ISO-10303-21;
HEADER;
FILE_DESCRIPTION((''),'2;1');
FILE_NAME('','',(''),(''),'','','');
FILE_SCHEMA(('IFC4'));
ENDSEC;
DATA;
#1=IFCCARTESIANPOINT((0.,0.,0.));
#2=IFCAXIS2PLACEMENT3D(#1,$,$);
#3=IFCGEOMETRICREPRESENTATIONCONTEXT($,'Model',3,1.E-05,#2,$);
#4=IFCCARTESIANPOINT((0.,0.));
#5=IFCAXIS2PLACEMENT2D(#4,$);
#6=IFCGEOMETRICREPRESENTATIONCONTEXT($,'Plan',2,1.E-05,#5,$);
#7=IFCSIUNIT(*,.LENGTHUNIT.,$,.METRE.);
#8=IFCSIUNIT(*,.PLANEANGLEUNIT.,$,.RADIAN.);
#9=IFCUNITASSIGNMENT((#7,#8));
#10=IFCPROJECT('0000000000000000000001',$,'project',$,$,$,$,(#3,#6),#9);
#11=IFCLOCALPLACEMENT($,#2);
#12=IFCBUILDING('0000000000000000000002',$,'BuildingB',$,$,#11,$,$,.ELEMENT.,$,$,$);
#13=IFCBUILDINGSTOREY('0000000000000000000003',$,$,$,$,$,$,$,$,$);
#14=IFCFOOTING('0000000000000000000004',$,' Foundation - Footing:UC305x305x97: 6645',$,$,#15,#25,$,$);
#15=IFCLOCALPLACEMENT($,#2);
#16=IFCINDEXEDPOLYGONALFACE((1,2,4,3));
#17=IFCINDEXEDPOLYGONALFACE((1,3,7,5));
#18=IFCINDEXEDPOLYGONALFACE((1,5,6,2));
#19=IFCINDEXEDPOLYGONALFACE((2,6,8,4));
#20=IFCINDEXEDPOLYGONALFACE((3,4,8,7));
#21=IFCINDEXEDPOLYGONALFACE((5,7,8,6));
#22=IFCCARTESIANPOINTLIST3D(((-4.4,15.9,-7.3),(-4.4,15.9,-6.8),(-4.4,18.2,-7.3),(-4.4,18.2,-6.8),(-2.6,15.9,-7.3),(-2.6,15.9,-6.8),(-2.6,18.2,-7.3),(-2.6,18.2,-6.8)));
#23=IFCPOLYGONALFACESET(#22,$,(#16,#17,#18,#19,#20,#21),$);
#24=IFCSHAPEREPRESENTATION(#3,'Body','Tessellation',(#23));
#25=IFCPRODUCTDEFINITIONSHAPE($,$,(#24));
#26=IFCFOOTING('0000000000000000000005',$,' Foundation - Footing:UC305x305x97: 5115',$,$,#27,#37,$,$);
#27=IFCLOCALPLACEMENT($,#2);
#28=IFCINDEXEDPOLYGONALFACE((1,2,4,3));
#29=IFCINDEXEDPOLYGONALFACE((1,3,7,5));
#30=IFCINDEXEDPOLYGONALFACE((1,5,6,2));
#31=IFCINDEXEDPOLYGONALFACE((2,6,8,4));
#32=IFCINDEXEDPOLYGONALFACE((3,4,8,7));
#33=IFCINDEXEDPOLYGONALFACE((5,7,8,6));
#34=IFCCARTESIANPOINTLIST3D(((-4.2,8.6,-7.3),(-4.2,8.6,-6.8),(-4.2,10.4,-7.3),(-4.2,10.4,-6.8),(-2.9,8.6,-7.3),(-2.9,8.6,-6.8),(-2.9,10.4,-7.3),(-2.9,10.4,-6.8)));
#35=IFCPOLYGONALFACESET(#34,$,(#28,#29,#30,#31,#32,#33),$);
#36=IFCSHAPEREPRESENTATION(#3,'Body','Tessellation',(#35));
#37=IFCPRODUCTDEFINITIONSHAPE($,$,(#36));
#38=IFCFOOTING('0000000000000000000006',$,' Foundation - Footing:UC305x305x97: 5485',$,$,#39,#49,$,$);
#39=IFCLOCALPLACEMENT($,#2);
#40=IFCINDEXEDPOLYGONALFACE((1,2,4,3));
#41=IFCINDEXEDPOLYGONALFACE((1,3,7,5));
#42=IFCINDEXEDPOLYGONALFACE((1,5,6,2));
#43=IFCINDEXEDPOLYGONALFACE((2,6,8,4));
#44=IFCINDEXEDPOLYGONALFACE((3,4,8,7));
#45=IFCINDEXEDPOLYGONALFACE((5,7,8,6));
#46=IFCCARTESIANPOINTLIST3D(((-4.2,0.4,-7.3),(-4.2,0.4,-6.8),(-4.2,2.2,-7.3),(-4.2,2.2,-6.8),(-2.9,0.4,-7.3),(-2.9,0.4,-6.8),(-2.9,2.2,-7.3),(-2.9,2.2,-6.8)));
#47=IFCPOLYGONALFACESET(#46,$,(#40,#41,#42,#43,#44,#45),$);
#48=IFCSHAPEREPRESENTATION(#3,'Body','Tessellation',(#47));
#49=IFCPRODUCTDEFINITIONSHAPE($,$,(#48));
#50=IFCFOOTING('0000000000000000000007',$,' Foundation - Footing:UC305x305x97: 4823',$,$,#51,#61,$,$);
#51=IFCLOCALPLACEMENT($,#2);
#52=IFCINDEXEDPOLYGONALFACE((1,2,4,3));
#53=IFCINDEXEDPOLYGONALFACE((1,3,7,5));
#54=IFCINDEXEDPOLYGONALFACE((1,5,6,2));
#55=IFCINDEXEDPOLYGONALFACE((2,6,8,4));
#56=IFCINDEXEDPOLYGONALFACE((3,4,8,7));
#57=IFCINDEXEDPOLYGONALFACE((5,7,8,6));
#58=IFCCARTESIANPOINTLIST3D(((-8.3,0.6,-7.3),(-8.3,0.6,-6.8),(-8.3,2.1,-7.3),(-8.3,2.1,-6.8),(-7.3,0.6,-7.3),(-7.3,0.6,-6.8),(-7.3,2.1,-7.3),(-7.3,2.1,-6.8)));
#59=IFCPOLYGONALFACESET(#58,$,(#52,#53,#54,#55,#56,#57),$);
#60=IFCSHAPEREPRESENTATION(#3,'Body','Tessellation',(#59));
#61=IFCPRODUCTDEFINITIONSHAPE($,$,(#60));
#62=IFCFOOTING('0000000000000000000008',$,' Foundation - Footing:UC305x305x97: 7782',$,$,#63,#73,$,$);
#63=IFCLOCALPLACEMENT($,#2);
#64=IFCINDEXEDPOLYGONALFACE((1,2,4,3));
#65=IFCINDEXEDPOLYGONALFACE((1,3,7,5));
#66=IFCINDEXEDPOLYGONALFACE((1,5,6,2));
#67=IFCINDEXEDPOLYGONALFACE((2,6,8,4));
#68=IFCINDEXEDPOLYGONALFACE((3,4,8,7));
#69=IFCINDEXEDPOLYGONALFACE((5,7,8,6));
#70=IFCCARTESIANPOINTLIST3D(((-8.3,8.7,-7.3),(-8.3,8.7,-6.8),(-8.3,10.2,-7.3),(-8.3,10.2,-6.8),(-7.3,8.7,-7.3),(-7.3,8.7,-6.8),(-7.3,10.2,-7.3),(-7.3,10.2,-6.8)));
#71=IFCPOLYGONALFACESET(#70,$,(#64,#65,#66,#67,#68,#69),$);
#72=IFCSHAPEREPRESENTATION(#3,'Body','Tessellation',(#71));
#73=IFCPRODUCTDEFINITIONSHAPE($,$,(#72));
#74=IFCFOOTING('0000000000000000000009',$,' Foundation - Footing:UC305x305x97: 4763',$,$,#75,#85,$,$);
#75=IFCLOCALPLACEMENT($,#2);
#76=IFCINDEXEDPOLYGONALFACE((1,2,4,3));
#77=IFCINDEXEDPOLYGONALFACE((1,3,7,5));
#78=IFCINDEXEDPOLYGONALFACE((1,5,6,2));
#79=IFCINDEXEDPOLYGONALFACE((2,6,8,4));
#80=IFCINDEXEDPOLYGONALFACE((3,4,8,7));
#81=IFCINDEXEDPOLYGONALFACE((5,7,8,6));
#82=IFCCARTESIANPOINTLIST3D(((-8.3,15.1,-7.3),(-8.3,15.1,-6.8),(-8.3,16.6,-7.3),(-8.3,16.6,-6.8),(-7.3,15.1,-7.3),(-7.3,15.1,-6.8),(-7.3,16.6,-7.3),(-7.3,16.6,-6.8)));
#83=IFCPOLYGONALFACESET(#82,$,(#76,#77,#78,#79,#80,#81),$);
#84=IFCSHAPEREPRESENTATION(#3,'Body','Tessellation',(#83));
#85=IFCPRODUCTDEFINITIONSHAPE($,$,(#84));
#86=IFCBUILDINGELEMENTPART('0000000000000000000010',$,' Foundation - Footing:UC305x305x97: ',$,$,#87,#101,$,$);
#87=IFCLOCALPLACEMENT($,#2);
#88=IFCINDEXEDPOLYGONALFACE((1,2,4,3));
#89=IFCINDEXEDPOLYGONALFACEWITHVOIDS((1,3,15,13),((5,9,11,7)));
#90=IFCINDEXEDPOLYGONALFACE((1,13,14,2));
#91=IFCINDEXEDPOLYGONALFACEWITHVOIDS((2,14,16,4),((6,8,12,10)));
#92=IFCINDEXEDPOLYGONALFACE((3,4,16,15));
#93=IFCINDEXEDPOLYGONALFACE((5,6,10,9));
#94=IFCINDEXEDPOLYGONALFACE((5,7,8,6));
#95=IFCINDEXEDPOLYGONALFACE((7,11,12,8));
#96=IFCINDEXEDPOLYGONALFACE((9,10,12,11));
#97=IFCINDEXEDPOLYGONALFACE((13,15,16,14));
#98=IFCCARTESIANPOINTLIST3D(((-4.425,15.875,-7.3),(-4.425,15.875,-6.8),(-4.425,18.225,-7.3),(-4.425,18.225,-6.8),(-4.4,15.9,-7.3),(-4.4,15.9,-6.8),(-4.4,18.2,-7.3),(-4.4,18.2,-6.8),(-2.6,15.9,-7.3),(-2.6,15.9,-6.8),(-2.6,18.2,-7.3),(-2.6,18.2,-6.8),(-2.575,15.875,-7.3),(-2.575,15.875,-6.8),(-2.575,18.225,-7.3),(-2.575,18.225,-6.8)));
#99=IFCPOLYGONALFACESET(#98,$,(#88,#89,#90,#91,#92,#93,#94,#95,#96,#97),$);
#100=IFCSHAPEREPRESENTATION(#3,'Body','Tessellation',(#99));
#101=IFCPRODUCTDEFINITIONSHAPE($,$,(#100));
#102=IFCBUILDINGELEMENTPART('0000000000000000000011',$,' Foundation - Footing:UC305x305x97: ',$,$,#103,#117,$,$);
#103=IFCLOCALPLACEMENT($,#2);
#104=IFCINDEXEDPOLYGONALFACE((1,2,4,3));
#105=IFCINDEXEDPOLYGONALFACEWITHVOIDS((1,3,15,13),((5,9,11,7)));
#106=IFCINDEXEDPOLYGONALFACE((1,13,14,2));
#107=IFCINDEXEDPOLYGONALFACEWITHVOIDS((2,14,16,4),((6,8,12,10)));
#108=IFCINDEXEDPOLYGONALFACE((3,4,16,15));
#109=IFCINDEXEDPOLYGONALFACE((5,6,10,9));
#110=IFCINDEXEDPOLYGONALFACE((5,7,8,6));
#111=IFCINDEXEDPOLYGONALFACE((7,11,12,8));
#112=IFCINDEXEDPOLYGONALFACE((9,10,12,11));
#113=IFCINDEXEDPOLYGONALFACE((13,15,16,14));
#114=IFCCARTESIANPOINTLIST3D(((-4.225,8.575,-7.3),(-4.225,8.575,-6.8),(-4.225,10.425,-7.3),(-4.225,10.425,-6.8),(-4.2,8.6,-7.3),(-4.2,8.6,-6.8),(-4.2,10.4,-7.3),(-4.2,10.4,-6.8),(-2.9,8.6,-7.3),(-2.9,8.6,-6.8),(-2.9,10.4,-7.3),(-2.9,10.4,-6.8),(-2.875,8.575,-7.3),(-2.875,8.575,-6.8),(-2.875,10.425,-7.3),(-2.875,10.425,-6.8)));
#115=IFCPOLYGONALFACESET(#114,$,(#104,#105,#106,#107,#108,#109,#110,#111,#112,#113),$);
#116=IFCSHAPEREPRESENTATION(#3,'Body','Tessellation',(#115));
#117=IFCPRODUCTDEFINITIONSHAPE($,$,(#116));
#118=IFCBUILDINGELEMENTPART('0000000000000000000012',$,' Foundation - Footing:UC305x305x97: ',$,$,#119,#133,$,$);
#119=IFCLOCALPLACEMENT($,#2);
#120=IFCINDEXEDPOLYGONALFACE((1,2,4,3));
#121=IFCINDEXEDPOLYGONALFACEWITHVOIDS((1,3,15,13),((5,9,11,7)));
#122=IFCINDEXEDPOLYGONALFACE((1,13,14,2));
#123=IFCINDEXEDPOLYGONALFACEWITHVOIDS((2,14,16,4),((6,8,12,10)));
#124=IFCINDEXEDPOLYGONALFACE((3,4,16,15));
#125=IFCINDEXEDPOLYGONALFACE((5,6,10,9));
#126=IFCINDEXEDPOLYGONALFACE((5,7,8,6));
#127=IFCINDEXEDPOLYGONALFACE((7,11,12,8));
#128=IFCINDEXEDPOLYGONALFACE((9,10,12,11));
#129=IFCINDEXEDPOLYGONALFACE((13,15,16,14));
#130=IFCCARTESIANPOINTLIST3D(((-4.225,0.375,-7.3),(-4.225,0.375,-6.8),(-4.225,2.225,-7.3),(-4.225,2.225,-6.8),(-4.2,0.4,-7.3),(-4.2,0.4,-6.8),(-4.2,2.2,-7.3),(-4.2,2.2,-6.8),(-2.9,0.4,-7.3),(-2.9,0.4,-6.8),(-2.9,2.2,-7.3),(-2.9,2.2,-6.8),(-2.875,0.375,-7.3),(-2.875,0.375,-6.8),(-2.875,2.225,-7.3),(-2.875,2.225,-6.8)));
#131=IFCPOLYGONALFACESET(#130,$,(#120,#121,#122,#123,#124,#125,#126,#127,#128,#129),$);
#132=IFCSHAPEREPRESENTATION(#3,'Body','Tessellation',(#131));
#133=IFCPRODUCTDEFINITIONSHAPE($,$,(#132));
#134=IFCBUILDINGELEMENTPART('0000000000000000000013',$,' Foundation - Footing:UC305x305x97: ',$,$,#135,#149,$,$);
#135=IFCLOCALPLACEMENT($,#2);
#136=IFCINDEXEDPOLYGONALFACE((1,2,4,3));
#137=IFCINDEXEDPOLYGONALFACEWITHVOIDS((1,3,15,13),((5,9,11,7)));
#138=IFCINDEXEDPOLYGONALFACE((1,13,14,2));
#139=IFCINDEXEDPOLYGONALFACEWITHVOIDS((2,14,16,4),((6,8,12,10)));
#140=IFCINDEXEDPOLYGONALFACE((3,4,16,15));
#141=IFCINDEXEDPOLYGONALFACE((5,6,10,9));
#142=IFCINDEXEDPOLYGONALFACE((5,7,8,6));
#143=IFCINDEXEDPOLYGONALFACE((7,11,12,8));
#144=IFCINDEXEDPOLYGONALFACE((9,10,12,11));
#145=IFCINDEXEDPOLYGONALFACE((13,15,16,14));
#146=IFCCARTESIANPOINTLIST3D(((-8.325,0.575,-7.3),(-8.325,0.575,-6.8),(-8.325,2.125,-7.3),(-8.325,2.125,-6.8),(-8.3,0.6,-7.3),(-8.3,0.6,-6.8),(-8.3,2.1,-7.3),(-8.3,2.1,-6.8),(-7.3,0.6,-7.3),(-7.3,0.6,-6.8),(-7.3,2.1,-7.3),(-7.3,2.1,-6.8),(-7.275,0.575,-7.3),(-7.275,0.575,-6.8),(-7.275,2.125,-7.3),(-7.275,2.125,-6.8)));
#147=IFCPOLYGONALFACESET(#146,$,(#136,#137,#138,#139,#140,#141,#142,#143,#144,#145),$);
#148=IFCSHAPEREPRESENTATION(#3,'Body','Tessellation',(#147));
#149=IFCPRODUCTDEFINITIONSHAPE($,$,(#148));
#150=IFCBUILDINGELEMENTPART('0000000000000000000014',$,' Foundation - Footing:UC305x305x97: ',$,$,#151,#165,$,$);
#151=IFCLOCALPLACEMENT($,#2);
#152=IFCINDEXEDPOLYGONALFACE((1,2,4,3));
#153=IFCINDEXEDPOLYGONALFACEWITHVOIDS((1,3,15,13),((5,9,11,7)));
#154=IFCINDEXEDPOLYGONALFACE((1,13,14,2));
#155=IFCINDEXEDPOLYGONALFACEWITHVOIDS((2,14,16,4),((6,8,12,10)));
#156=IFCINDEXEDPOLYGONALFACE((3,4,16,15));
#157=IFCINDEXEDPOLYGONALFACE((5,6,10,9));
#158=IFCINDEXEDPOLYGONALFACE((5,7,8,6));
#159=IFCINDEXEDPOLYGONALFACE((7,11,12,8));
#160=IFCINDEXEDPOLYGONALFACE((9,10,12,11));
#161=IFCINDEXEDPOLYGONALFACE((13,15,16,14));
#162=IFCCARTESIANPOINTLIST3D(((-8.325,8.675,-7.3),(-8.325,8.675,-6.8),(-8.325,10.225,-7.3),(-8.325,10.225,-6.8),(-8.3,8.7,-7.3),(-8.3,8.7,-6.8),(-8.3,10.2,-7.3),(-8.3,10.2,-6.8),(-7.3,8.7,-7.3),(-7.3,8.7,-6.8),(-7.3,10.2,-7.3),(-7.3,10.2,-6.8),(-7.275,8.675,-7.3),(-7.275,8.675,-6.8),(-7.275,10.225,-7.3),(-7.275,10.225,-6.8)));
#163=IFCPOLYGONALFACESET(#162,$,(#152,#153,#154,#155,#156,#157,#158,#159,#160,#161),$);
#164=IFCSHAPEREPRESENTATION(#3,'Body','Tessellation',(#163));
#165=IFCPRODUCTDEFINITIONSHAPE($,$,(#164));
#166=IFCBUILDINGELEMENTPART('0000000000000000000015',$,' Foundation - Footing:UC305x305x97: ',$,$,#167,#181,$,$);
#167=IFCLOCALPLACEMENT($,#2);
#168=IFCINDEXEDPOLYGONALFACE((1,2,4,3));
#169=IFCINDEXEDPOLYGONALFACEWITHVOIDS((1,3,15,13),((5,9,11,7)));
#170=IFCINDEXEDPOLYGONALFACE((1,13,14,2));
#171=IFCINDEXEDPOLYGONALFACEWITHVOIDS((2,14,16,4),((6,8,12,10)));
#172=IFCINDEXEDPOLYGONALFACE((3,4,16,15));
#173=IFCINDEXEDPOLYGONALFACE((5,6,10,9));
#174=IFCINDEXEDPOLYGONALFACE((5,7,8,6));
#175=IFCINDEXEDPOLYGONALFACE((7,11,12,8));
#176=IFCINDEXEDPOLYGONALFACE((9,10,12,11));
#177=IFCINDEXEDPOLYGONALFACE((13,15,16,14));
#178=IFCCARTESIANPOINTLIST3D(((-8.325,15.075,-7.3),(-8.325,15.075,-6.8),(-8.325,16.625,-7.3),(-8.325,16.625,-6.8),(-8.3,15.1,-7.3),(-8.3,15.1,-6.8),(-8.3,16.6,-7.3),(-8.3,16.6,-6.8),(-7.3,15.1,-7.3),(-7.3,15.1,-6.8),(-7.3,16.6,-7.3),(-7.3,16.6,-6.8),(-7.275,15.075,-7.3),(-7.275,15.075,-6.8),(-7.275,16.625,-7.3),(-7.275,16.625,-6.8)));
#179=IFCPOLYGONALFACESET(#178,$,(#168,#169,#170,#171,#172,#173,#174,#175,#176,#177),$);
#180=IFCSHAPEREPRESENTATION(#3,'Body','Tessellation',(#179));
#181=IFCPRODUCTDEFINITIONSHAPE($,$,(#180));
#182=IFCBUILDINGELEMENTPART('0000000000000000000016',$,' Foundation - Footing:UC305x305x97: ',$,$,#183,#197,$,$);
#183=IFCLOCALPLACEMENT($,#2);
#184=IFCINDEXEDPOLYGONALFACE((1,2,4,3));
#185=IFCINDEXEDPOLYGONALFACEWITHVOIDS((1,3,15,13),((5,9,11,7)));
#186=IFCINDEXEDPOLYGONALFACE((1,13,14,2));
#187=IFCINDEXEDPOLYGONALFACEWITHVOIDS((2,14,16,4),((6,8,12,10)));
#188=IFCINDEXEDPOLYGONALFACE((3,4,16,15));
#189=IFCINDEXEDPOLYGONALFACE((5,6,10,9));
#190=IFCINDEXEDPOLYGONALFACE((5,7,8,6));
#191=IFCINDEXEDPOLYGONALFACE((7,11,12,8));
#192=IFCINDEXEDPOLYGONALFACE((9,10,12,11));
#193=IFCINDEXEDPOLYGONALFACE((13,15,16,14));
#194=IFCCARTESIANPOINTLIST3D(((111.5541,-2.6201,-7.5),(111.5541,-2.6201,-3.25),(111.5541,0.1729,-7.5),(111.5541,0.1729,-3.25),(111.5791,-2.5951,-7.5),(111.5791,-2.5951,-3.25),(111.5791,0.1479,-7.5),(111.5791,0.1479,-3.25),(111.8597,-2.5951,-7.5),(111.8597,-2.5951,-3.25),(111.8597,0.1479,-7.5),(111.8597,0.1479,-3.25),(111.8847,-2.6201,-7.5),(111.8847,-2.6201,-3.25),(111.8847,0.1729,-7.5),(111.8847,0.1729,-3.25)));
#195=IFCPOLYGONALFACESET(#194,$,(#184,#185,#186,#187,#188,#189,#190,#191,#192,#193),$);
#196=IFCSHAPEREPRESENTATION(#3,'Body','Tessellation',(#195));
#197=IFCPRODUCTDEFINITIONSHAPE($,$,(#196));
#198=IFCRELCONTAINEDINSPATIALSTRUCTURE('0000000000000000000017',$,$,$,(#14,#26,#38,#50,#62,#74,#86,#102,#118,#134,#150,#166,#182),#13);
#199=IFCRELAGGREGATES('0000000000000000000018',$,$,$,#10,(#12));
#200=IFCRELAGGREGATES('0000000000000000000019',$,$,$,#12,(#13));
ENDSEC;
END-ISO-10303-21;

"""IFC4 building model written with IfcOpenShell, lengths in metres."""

from ifc_helpers import new_model, si_unit, origin, origin_2d, place, context, project, spatial, polyline, outline, extrude, element, save


model = new_model("IFC4")

# Units and contexts
model_context = context("Model", 3, precision=1e-05, world=origin())
plan_context = context("Plan", 2, precision=1e-05, world=origin_2d())
ifc_project = project(units=[si_unit("LENGTHUNIT", "METRE"), si_unit("PLANEANGLEUNIT", "RADIAN")], contexts=[model_context, plan_context])

# Building, storey
building_placement = place(None, origin())
building = spatial("IfcBuilding", under=ifc_project, at=building_placement, Name="BuildingB", CompositionType="ELEMENT")
storey = spatial("IfcBuildingStorey", under=building)

# Footings
element("IfcFooting", 1, inside=storey, Name=" Foundation - Footing:UC305x305x97: 6645", context=model_context, shape_type="SweptSolid", body=[
    extrude(outline(polyline([(-2.6, 18.2, -7.3), (-4.4, 18.2, -7.3), (-4.4, 15.9, -7.3), (-2.6, 15.9, -7.3), (-2.6, 18.2, -7.3)])), None, (0.0, 0.0, 1.0), 0.5),
])
element("IfcFooting", 2, inside=storey, Name=" Foundation - Footing:UC305x305x97: 5115", context=model_context, shape_type="SweptSolid", body=[
    extrude(outline(polyline([(-2.9, 10.4, -7.3), (-4.2, 10.4, -7.3), (-4.2, 8.6, -7.3), (-2.9, 8.6, -7.3), (-2.9, 10.4, -7.3)])), None, (0.0, 0.0, 1.0), 0.5),
])
element("IfcFooting", 3, inside=storey, Name=" Foundation - Footing:UC305x305x97: 5485", context=model_context, shape_type="SweptSolid", body=[
    extrude(outline(polyline([(-2.9, 2.2, -7.3), (-4.2, 2.2, -7.3), (-4.2, 0.4, -7.3), (-2.9, 0.4, -7.3), (-2.9, 2.2, -7.3)])), None, (0.0, 0.0, 1.0), 0.5),
])
element("IfcFooting", 4, inside=storey, Name=" Foundation - Footing:UC305x305x97: 4823", context=model_context, shape_type="SweptSolid", body=[
    extrude(outline(polyline([(-7.3, 2.1, -7.3), (-8.3, 2.1, -7.3), (-8.3, 0.6, -7.3), (-7.3, 0.6, -7.3), (-7.3, 2.1, -7.3)])), None, (0.0, 0.0, 1.0), 0.5),
])
element("IfcFooting", 5, inside=storey, Name=" Foundation - Footing:UC305x305x97: 7782", context=model_context, shape_type="SweptSolid", body=[
    extrude(outline(polyline([(-7.3, 10.2, -7.3), (-8.3, 10.2, -7.3), (-8.3, 8.7, -7.3), (-7.3, 8.7, -7.3), (-7.3, 10.2, -7.3)])), None, (0.0, 0.0, 1.0), 0.5),
])
element("IfcFooting", 6, inside=storey, Name=" Foundation - Footing:UC305x305x97: 4763", context=model_context, shape_type="SweptSolid", body=[
    extrude(outline(polyline([(-7.3, 16.6, -7.3), (-8.3, 16.6, -7.3), (-8.3, 15.1, -7.3), (-7.3, 15.1, -7.3), (-7.3, 16.6, -7.3)])), None, (0.0, 0.0, 1.0), 0.5),
])

# Building element parts, openings
building_element_part_1 = element("IfcBuildingElementPart", 7, inside=storey, Name=" Foundation - Footing:UC305x305x97: ", context=model_context, shape_type="SweptSolid", body=[
    extrude(outline(polyline([(-2.575, 18.225, -7.3), (-4.425, 18.225, -7.3), (-4.425, 15.875, -7.3), (-2.575, 15.875, -7.3), (-2.575, 18.225, -7.3)])), None, (0.0, 0.0, 1.0), 0.5),
])
element("IfcOpeningElement", 8, inside=storey, cuts=building_element_part_1, context=model_context, shape_type="SweptSolid", body=[
    extrude(outline(polyline([(-2.6, 18.2, -7.3), (-4.4, 18.2, -7.3), (-4.4, 15.9, -7.3), (-2.6, 15.9, -7.3), (-2.6, 18.2, -7.3)])), None, (0.0, 0.0, 1.0), 0.5),
])
building_element_part_2 = element("IfcBuildingElementPart", 9, inside=storey, Name=" Foundation - Footing:UC305x305x97: ", context=model_context, shape_type="SweptSolid", body=[
    extrude(outline(polyline([(-2.875, 10.425, -7.3), (-4.225, 10.425, -7.3), (-4.225, 8.575, -7.3), (-2.875, 8.575, -7.3), (-2.875, 10.425, -7.3)])), None, (0.0, 0.0, 1.0), 0.5),
])
element("IfcOpeningElement", 10, inside=storey, cuts=building_element_part_2, context=model_context, shape_type="SweptSolid", body=[
    extrude(outline(polyline([(-2.9, 10.4, -7.3), (-4.2, 10.4, -7.3), (-4.2, 8.6, -7.3), (-2.9, 8.6, -7.3), (-2.9, 10.4, -7.3)])), None, (0.0, 0.0, 1.0), 0.5),
])
building_element_part_3 = element("IfcBuildingElementPart", 11, inside=storey, Name=" Foundation - Footing:UC305x305x97: ", context=model_context, shape_type="SweptSolid", body=[
    extrude(outline(polyline([(-2.875, 2.225, -7.3), (-4.225, 2.225, -7.3), (-4.225, 0.375, -7.3), (-2.875, 0.375, -7.3), (-2.875, 2.225, -7.3)])), None, (0.0, 0.0, 1.0), 0.5),
])
element("IfcOpeningElement", 12, inside=storey, cuts=building_element_part_3, context=model_context, shape_type="SweptSolid", body=[
    extrude(outline(polyline([(-2.9, 2.2, -7.3), (-4.2, 2.2, -7.3), (-4.2, 0.4, -7.3), (-2.9, 0.4, -7.3), (-2.9, 2.2, -7.3)])), None, (0.0, 0.0, 1.0), 0.5),
])
building_element_part_4 = element("IfcBuildingElementPart", 13, inside=storey, Name=" Foundation - Footing:UC305x305x97: ", context=model_context, shape_type="SweptSolid", body=[
    extrude(outline(polyline([(-7.275, 2.125, -7.3), (-8.325, 2.125, -7.3), (-8.325, 0.575, -7.3), (-7.275, 0.575, -7.3), (-7.275, 2.125, -7.3)])), None, (0.0, 0.0, 1.0), 0.5),
])
element("IfcOpeningElement", 14, inside=storey, cuts=building_element_part_4, context=model_context, shape_type="SweptSolid", body=[
    extrude(outline(polyline([(-7.3, 2.1, -7.3), (-8.3, 2.1, -7.3), (-8.3, 0.6, -7.3), (-7.3, 0.6, -7.3), (-7.3, 2.1, -7.3)])), None, (0.0, 0.0, 1.0), 0.5),
])
building_element_part_5 = element("IfcBuildingElementPart", 15, inside=storey, Name=" Foundation - Footing:UC305x305x97: ", context=model_context, shape_type="SweptSolid", body=[
    extrude(outline(polyline([(-7.275, 10.225, -7.3), (-8.325, 10.225, -7.3), (-8.325, 8.675, -7.3), (-7.275, 8.675, -7.3), (-7.275, 10.225, -7.3)])), None, (0.0, 0.0, 1.0), 0.5),
])
element("IfcOpeningElement", 16, inside=storey, cuts=building_element_part_5, context=model_context, shape_type="SweptSolid", body=[
    extrude(outline(polyline([(-7.3, 10.2, -7.3), (-8.3, 10.2, -7.3), (-8.3, 8.7, -7.3), (-7.3, 8.7, -7.3), (-7.3, 10.2, -7.3)])), None, (0.0, 0.0, 1.0), 0.5),
])
building_element_part_6 = element("IfcBuildingElementPart", 17, inside=storey, Name=" Foundation - Footing:UC305x305x97: ", context=model_context, shape_type="SweptSolid", body=[
    extrude(outline(polyline([(-7.275, 16.625, -7.3), (-8.325, 16.625, -7.3), (-8.325, 15.075, -7.3), (-7.275, 15.075, -7.3), (-7.275, 16.625, -7.3)])), None, (0.0, 0.0, 1.0), 0.5),
])
element("IfcOpeningElement", 18, inside=storey, cuts=building_element_part_6, context=model_context, shape_type="SweptSolid", body=[
    extrude(outline(polyline([(-7.3, 16.6, -7.3), (-8.3, 16.6, -7.3), (-8.3, 15.1, -7.3), (-7.3, 15.1, -7.3), (-7.3, 16.6, -7.3)])), None, (0.0, 0.0, 1.0), 0.5),
])
building_element_part_7 = element("IfcBuildingElementPart", 19, inside=storey, Name=" Foundation - Footing:UC305x305x97: ", context=model_context, shape_type="SweptSolid", body=[
    extrude(outline(polyline([(111.5541, -2.6201, -7.5), (111.5541, 0.1729, -7.5), (111.8847, 0.1729, -7.5), (111.8847, -2.6201, -7.5), (111.5541, -2.6201, -7.5)])), None, (0.0, 0.0, 1.0), 4.25),
])
element("IfcOpeningElement", 20, inside=storey, cuts=building_element_part_7, context=model_context, shape_type="SweptSolid", body=[
    extrude(outline(polyline([(111.5791, -2.5951, -7.5), (111.5791, 0.1479, -7.5), (111.8597, 0.1479, -7.5), (111.8597, -2.5951, -7.5), (111.5791, -2.5951, -7.5)])), None, (0.0, 0.0, 1.0), 4.25),
])

save(model, "model.ifc")
